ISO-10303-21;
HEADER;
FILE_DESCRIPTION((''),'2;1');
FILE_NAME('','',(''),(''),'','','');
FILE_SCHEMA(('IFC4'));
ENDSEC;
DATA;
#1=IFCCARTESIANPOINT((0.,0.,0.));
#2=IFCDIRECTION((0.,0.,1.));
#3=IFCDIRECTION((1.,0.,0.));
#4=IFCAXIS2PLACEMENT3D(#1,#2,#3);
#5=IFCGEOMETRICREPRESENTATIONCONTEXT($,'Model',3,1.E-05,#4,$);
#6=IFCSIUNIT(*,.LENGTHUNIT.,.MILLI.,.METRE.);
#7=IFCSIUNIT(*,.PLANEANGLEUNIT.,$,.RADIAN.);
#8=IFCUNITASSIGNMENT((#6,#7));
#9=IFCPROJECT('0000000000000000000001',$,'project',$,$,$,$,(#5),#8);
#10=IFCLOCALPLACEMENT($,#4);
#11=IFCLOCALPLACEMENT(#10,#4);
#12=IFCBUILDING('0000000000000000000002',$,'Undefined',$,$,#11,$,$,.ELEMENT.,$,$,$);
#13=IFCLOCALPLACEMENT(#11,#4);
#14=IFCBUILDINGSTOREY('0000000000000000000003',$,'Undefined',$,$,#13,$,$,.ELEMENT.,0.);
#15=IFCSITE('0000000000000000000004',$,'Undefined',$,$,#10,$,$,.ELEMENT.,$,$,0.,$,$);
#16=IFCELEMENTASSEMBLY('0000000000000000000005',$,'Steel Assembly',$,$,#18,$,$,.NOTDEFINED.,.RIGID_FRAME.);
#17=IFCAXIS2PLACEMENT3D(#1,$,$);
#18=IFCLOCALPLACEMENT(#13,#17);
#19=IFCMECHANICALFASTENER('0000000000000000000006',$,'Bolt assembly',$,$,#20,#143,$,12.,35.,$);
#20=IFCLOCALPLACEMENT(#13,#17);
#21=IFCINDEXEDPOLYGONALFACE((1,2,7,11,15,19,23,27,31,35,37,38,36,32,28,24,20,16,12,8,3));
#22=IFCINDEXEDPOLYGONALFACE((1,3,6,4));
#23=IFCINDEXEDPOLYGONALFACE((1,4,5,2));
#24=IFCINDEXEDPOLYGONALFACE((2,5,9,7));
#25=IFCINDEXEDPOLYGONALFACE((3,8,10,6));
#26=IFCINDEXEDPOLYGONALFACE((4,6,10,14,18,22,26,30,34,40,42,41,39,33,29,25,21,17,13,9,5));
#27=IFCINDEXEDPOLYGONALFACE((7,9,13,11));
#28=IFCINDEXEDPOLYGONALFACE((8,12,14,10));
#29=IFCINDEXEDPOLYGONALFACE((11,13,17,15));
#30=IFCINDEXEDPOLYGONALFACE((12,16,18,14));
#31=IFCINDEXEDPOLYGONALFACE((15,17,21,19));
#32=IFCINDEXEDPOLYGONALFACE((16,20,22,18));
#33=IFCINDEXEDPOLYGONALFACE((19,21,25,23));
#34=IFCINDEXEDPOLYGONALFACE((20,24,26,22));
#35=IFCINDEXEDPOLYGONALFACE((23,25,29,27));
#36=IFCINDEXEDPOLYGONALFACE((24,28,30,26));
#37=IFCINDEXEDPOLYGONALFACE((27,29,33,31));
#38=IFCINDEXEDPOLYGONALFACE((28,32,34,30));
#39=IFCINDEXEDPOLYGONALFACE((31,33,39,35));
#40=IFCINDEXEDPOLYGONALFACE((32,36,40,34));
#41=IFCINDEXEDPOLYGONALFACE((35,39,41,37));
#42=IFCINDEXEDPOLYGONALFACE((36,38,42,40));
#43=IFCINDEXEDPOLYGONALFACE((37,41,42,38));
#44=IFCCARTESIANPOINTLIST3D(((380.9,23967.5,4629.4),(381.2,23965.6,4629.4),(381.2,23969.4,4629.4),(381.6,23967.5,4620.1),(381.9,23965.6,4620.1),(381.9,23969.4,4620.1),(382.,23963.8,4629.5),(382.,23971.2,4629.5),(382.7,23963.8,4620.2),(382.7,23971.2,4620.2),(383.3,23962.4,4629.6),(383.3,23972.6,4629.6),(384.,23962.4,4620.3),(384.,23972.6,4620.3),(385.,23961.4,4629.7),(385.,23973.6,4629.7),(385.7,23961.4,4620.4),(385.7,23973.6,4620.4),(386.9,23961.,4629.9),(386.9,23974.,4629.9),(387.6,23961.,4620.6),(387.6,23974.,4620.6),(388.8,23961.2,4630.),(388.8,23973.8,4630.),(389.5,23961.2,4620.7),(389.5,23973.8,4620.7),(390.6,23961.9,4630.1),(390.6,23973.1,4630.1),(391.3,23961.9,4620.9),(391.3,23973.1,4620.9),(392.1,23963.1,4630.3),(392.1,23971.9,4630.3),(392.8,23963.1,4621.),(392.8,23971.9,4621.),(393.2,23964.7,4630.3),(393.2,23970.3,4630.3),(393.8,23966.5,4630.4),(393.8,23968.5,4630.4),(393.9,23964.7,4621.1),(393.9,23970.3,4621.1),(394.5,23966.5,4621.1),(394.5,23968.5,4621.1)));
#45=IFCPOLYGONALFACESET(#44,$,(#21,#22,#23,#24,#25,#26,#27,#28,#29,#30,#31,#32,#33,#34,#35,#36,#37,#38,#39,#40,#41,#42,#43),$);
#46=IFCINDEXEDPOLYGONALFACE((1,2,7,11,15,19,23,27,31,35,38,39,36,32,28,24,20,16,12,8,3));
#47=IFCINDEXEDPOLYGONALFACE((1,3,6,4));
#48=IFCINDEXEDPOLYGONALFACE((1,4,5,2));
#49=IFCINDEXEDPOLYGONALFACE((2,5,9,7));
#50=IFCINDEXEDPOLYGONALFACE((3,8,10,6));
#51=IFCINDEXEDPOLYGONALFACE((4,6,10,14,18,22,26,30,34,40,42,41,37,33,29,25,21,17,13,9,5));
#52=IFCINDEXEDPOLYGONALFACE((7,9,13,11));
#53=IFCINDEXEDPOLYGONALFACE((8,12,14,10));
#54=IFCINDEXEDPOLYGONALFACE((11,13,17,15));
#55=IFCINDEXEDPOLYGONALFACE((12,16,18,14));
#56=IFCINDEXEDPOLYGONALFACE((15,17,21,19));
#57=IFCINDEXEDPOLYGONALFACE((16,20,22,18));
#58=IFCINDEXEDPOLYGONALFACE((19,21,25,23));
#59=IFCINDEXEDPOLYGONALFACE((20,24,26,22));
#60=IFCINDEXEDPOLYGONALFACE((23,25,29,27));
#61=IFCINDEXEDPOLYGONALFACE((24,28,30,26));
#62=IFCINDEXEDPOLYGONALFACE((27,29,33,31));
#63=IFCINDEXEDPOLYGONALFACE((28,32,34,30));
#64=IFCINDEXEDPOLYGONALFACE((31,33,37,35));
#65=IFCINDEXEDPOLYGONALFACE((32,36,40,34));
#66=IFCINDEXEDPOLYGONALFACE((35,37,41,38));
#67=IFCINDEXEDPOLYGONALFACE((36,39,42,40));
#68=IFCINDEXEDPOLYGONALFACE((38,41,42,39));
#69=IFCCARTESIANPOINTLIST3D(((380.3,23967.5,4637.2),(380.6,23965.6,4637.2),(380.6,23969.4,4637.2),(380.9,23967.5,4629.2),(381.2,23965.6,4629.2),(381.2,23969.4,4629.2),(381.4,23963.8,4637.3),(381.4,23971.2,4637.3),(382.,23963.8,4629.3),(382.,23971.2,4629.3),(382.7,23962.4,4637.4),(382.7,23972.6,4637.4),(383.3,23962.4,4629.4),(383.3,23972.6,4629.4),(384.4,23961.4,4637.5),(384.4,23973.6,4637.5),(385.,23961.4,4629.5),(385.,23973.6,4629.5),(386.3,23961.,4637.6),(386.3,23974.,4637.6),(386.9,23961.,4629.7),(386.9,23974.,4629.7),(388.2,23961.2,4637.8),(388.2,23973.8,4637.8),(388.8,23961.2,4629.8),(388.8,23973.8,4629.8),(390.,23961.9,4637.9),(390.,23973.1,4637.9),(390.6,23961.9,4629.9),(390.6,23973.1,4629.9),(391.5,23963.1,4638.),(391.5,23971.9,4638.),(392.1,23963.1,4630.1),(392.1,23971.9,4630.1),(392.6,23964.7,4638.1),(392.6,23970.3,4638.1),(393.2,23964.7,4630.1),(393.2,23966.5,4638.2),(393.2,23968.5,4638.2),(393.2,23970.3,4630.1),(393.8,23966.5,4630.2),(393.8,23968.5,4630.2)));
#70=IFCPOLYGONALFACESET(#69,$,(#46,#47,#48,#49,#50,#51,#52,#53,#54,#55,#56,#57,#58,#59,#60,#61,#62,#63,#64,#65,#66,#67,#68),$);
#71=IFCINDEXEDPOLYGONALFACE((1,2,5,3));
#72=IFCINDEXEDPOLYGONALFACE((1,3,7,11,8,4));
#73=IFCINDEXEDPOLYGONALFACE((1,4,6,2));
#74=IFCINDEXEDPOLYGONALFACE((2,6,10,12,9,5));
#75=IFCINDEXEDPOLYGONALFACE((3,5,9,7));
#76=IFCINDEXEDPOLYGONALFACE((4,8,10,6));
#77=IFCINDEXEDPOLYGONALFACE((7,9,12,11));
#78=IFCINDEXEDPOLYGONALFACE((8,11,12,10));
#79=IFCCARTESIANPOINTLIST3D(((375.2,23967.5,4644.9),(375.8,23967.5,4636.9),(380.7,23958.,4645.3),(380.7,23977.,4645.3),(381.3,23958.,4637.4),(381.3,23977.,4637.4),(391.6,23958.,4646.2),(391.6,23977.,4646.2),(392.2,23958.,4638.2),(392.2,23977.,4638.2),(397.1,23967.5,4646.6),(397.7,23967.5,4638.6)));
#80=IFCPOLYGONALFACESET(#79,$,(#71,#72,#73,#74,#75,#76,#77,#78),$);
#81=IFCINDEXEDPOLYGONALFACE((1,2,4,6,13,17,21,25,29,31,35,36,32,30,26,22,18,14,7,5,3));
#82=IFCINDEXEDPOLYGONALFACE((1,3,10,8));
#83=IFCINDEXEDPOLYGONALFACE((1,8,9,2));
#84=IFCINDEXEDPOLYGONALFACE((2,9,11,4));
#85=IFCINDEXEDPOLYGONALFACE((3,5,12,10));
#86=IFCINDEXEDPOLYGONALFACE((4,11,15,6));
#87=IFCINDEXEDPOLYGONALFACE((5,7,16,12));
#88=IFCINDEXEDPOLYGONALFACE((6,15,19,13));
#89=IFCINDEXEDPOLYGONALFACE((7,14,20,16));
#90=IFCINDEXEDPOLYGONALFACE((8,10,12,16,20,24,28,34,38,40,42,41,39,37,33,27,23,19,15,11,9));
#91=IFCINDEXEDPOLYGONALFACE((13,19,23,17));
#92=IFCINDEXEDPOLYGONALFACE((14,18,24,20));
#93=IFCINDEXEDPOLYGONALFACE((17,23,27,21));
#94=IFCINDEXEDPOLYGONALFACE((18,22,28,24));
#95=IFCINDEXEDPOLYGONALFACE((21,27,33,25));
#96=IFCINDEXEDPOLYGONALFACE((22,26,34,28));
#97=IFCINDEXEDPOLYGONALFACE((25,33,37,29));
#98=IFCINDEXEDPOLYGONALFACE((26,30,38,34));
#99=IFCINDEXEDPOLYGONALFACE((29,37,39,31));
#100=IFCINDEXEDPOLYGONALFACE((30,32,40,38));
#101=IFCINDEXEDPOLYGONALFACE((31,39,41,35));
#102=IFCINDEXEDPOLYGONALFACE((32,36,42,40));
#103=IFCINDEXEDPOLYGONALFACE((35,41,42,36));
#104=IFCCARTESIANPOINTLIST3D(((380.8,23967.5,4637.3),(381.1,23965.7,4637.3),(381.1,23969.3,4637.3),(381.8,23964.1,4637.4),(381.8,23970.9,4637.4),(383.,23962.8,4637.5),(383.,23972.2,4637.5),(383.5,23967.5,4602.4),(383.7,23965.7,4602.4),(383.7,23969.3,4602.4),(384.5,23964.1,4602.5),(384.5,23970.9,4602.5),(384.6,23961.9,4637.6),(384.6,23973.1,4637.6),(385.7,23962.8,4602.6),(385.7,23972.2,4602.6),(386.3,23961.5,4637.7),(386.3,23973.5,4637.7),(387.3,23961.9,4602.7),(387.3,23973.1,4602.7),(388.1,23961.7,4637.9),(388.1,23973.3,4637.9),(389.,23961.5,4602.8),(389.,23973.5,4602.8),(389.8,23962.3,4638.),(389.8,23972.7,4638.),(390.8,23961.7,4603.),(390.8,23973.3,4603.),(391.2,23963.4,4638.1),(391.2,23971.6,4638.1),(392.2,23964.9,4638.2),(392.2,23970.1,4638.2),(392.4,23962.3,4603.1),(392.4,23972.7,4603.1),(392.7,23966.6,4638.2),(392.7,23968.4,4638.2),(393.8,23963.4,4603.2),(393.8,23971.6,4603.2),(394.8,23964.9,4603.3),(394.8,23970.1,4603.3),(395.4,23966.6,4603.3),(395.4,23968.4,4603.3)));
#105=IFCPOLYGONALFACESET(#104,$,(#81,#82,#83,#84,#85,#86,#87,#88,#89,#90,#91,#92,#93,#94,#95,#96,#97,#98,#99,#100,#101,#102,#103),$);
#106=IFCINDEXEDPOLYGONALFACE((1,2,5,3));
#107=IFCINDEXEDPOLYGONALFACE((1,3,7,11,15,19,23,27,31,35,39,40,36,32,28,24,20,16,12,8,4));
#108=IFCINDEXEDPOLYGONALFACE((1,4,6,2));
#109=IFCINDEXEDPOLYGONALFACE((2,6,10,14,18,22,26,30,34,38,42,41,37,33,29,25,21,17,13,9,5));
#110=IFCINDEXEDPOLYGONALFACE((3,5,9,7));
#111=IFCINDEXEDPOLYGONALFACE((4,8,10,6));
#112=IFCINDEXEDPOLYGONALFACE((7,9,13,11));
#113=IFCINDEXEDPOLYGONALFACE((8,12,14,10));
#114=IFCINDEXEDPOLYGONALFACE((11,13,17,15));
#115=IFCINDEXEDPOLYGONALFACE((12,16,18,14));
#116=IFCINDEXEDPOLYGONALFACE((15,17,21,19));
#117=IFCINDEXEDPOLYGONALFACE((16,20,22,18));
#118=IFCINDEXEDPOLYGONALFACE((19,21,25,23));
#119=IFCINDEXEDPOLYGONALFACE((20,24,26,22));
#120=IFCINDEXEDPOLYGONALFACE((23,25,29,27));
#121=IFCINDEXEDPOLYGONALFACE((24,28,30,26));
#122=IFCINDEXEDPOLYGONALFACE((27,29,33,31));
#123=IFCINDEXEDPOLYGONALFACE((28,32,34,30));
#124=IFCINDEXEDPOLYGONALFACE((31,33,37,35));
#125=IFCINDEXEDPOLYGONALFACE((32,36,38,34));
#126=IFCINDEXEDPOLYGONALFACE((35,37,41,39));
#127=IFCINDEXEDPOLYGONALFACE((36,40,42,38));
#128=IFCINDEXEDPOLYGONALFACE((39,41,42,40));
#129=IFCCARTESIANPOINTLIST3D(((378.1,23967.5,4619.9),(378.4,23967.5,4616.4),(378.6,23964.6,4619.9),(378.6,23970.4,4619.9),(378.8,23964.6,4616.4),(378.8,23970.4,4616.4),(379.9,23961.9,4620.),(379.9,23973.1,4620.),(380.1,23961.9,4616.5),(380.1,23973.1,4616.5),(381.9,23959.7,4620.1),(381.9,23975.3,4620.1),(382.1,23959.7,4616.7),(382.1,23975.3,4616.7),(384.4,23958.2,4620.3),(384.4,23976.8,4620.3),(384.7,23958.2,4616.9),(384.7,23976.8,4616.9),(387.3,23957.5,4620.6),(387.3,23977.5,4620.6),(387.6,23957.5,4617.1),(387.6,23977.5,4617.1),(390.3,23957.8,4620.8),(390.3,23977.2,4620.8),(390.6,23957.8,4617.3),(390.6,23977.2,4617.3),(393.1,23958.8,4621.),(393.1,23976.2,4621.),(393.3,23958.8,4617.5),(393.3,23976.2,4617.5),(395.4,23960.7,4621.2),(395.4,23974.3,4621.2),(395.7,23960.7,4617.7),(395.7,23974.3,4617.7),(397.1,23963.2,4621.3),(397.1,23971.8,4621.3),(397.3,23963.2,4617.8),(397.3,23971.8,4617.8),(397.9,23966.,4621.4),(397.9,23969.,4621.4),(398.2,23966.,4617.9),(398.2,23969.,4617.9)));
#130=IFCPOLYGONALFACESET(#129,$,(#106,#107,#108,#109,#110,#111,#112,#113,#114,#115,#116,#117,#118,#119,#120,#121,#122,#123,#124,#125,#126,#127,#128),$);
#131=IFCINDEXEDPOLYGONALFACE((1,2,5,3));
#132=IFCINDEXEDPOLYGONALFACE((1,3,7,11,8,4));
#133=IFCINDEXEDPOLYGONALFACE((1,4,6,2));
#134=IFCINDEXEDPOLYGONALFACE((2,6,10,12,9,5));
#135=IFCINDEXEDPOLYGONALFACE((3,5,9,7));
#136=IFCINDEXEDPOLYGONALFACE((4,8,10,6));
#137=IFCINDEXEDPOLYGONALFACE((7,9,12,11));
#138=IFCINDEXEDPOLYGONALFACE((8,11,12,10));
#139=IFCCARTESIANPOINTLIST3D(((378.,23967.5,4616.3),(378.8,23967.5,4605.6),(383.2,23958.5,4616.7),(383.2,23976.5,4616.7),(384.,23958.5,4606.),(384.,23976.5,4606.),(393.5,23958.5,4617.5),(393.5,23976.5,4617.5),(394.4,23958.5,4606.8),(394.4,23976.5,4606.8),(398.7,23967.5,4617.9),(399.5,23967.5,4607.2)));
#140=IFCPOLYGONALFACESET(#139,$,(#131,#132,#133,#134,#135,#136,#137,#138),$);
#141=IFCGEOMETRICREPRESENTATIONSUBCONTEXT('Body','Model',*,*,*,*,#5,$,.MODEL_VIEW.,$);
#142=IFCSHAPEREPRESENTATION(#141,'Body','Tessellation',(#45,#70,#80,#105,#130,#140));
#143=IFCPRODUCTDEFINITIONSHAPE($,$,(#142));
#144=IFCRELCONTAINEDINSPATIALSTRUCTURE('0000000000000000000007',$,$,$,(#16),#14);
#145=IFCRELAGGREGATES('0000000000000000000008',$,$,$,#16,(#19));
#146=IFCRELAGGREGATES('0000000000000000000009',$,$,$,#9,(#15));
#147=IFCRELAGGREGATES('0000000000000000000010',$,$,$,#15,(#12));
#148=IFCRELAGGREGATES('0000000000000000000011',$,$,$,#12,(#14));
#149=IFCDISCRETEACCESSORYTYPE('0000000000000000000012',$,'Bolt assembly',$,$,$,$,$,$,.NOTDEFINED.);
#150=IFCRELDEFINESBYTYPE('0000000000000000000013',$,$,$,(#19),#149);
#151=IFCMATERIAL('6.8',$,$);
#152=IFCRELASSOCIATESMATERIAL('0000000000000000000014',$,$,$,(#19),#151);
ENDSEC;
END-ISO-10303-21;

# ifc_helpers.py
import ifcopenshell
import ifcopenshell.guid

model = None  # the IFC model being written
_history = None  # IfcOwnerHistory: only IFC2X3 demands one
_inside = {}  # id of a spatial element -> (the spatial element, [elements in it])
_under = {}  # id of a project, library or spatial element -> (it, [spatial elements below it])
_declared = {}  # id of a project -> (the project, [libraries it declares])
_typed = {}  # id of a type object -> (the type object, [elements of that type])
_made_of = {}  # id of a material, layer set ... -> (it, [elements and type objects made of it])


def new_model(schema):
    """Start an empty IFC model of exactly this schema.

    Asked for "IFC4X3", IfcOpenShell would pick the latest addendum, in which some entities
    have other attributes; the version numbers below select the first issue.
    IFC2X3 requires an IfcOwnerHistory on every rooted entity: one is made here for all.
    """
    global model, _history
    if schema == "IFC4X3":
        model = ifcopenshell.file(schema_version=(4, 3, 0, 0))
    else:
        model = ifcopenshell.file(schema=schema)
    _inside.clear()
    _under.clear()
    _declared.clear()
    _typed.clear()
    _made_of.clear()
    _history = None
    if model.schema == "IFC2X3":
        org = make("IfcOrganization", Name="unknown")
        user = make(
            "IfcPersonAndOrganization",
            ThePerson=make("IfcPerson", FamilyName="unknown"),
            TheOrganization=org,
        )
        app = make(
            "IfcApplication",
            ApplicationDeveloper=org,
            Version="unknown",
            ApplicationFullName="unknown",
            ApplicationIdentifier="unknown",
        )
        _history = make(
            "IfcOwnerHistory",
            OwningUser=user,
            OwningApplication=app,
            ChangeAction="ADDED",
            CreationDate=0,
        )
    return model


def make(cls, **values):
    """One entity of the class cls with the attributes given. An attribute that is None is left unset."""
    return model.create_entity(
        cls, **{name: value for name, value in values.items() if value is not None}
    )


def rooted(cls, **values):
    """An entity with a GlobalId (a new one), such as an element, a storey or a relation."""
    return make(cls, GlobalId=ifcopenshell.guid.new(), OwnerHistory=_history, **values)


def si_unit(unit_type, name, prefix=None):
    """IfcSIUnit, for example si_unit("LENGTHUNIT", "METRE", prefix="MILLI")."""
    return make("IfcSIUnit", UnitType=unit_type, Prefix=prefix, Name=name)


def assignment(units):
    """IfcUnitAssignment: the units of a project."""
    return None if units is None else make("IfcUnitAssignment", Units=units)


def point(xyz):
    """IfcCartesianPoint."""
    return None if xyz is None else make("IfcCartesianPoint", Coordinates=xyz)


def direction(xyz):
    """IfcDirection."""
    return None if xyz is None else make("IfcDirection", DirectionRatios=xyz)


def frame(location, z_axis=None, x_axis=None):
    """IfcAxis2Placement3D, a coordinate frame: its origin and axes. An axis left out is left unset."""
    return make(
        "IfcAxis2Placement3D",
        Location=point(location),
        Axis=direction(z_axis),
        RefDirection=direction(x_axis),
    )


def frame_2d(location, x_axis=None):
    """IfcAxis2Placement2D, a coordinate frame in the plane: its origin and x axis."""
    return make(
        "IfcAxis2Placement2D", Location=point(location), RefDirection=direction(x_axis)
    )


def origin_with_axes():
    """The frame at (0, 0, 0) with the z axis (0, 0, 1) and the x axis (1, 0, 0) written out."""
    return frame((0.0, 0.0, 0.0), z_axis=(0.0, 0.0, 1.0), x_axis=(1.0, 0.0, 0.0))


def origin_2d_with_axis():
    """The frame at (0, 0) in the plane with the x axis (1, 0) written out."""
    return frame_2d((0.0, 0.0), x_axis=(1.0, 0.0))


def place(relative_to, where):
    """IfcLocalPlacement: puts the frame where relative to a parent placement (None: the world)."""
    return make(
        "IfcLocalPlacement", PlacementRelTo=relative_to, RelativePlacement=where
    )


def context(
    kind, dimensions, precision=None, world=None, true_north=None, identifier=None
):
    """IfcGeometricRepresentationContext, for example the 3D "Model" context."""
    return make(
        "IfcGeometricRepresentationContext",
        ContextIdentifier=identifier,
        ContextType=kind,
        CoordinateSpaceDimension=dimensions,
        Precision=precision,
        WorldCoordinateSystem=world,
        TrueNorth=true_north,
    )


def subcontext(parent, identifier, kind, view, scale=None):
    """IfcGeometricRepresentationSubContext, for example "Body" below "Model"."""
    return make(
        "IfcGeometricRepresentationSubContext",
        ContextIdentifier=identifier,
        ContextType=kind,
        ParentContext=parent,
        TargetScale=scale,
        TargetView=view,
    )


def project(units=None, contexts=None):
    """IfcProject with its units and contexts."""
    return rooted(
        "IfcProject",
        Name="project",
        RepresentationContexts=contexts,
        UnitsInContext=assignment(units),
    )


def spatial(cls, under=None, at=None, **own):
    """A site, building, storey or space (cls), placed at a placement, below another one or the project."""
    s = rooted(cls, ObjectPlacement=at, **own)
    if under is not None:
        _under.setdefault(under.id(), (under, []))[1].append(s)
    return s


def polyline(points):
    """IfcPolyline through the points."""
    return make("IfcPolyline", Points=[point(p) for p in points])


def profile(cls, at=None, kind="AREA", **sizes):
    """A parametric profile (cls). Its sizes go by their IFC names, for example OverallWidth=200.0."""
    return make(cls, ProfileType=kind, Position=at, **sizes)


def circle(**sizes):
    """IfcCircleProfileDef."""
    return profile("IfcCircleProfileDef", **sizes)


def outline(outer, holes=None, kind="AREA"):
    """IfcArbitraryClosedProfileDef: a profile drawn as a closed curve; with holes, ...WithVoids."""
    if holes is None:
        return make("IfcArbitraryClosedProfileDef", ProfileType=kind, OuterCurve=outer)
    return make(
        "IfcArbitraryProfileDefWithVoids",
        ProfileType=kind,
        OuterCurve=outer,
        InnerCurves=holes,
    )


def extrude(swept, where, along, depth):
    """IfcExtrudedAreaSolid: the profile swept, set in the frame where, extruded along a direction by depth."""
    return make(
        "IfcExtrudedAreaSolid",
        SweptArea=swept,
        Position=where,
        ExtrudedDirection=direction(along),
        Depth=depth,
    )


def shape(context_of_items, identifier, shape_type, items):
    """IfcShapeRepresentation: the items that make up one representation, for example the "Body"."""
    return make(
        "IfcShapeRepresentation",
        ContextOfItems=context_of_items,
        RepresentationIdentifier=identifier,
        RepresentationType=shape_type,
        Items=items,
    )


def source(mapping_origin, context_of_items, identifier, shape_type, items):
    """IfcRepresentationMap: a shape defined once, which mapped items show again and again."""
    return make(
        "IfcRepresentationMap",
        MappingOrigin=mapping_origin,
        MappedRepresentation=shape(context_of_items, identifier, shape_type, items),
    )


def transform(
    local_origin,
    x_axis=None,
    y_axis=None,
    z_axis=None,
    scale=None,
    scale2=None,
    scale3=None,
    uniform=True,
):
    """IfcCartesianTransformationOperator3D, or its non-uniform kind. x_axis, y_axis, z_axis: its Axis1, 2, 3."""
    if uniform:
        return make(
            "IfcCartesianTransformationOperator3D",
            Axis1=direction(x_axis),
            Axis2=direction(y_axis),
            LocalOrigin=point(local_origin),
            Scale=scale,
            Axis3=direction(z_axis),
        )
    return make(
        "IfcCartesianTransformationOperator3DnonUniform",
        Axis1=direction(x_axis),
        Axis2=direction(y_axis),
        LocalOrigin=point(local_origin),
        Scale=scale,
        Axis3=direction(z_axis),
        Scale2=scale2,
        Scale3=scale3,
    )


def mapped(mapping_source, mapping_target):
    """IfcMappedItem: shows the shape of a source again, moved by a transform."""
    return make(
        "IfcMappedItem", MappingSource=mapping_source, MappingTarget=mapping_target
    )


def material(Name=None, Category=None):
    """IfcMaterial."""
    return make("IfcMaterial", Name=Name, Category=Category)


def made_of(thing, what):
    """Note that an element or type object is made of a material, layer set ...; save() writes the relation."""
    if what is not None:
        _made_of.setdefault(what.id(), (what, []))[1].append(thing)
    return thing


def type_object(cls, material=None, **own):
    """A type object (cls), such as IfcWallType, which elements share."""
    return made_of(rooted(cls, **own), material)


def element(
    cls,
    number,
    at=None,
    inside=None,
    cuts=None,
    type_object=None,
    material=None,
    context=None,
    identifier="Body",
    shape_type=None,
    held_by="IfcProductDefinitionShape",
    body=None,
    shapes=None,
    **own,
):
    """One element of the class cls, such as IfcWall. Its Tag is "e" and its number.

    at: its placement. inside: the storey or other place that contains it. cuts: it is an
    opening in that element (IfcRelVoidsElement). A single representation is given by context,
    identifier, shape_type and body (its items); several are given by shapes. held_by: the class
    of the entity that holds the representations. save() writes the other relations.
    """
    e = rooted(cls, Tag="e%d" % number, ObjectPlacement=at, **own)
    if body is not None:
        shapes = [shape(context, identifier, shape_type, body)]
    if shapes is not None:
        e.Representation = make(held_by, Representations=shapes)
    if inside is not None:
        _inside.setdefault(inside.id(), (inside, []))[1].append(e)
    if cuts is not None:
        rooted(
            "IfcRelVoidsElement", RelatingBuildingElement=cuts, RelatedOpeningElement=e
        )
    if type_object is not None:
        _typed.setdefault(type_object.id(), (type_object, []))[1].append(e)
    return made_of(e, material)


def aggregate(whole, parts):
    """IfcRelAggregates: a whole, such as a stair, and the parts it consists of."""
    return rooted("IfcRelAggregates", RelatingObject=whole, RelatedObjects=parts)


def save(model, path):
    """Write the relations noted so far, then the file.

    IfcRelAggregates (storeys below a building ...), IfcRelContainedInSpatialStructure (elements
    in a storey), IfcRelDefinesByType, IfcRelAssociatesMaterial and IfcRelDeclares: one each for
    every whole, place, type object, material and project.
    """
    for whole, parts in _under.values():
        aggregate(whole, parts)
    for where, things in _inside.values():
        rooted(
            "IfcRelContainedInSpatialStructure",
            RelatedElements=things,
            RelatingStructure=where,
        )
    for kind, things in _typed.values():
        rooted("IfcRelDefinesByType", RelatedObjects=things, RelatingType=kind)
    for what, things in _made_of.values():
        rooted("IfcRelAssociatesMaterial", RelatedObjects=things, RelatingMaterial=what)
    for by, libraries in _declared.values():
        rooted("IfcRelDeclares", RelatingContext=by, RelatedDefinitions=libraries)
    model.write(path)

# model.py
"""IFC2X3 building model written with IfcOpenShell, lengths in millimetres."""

from ifc_helpers import new_model, si_unit, frame, origin_with_axes, origin_2d_with_axis, place, context, subcontext, project, spatial, polyline, circle, outline, extrude, source, transform, mapped, material, type_object, element, aggregate, save


model = new_model("IFC2X3")

# Units and contexts
model_context = context("Model", 3, precision=1e-05, world=origin_with_axes())
body_context = subcontext(model_context, "Body", "Model", "MODEL_VIEW")
ifc_project = project(units=[si_unit("LENGTHUNIT", "METRE", prefix="MILLI"), si_unit("PLANEANGLEUNIT", "RADIAN")], contexts=[model_context])

# Site, building, storey
site_placement = place(None, origin_with_axes())
site = spatial("IfcSite", under=ifc_project, at=site_placement, Name="Undefined", CompositionType="ELEMENT", RefElevation=0.0)
building_placement = place(site_placement, origin_with_axes())
building = spatial("IfcBuilding", under=site, at=building_placement, Name="Undefined", CompositionType="ELEMENT")
storey_placement = place(building_placement, origin_with_axes())
storey = spatial("IfcBuildingStorey", under=building, at=storey_placement, Name="Undefined", CompositionType="ELEMENT", Elevation=0.0)

# Element assembly, mechanical fastener
ifc_material_1 = material(Name="6.8")
discrete_accessory_type_1 = type_object("IfcDiscreteAccessoryType", Name="Bolt assembly")
assembly_1_placement = place(storey_placement, origin_with_axes())
assembly_1 = element("IfcElementAssembly", 1, at=assembly_1_placement, inside=storey, Name="Steel Assembly", AssemblyPlace="NOTDEFINED", PredefinedType="RIGID_FRAME")
shared_shape_1 = source(origin_with_axes(), body_context, "Body", "SweptSolid", [
    extrude(circle(Radius=6.5, at=origin_2d_with_axis()), frame((0.0, -0.1, 0.0), z_axis=(0.0, 1.0, 0.0), x_axis=(1.0, 0.0, 0.0)), (0.0, 0.0, 1.0), 9.3),
    extrude(circle(Radius=6.5, at=origin_2d_with_axis()), frame((0.0, -7.9, 0.0), z_axis=(0.0, 1.0, 0.0), x_axis=(1.0, 0.0, 0.0)), (0.0, 0.0, 1.0), 8.0),
    extrude(outline(polyline([(11.0, 0.0), (5.5, 9.5), (-5.5, 9.5), (-11.0, 0.0), (-5.5, -9.5), (5.5, -9.5), (11.0, 0.0)])), frame((0.0, -16.0, 0.0), z_axis=(0.0, 1.0, 0.0), x_axis=(1.0, 0.0, 0.0)), (0.0, 0.0, 1.0), 8.0),
    extrude(circle(Radius=6.0, at=origin_2d_with_axis()), frame((0.0, -8.0, 0.0), z_axis=(0.0, 1.0, 0.0), x_axis=(1.0, 0.0, 0.0)), (0.0, 0.0, 1.0), 35.0),
    extrude(circle(Radius=10.0, at=origin_2d_with_axis()), frame((0.0, 9.2, 0.0), z_axis=(0.0, 1.0, 0.0), x_axis=(1.0, 0.0, 0.0)), (0.0, 0.0, 1.0), 3.5),
    extrude(outline(polyline([(10.4, 0.0), (5.2, 9.0), (-5.2, 9.0), (-10.4, 0.0), (-5.2, -9.0), (5.2, -9.0), (10.4, 0.0)])), frame((0.0, 12.7, 0.0), z_axis=(0.0, 1.0, 0.0), x_axis=(1.0, 0.0, 0.0)), (0.0, 0.0, 1.0), 10.8),
])
mechanical_fastener_1_placement = place(assembly_1_placement, frame((387.4, 23967.5, 4629.8), z_axis=(0.0, -1.0, 0.0), x_axis=(-0.997054, 0.0, -0.076696)))
mechanical_fastener_1 = element("IfcMechanicalFastener", 2, at=mechanical_fastener_1_placement, type_object=discrete_accessory_type_1, material=ifc_material_1, Name="Bolt assembly", NominalDiameter=12.0, NominalLength=35.0, context=body_context, shape_type="MappedRepresentation", body=[
    mapped(shared_shape_1, transform((0.0, 0.0, 0.0))),
])
aggregate(assembly_1, [mechanical_fastener_1])

save(model, "model.ifc")
